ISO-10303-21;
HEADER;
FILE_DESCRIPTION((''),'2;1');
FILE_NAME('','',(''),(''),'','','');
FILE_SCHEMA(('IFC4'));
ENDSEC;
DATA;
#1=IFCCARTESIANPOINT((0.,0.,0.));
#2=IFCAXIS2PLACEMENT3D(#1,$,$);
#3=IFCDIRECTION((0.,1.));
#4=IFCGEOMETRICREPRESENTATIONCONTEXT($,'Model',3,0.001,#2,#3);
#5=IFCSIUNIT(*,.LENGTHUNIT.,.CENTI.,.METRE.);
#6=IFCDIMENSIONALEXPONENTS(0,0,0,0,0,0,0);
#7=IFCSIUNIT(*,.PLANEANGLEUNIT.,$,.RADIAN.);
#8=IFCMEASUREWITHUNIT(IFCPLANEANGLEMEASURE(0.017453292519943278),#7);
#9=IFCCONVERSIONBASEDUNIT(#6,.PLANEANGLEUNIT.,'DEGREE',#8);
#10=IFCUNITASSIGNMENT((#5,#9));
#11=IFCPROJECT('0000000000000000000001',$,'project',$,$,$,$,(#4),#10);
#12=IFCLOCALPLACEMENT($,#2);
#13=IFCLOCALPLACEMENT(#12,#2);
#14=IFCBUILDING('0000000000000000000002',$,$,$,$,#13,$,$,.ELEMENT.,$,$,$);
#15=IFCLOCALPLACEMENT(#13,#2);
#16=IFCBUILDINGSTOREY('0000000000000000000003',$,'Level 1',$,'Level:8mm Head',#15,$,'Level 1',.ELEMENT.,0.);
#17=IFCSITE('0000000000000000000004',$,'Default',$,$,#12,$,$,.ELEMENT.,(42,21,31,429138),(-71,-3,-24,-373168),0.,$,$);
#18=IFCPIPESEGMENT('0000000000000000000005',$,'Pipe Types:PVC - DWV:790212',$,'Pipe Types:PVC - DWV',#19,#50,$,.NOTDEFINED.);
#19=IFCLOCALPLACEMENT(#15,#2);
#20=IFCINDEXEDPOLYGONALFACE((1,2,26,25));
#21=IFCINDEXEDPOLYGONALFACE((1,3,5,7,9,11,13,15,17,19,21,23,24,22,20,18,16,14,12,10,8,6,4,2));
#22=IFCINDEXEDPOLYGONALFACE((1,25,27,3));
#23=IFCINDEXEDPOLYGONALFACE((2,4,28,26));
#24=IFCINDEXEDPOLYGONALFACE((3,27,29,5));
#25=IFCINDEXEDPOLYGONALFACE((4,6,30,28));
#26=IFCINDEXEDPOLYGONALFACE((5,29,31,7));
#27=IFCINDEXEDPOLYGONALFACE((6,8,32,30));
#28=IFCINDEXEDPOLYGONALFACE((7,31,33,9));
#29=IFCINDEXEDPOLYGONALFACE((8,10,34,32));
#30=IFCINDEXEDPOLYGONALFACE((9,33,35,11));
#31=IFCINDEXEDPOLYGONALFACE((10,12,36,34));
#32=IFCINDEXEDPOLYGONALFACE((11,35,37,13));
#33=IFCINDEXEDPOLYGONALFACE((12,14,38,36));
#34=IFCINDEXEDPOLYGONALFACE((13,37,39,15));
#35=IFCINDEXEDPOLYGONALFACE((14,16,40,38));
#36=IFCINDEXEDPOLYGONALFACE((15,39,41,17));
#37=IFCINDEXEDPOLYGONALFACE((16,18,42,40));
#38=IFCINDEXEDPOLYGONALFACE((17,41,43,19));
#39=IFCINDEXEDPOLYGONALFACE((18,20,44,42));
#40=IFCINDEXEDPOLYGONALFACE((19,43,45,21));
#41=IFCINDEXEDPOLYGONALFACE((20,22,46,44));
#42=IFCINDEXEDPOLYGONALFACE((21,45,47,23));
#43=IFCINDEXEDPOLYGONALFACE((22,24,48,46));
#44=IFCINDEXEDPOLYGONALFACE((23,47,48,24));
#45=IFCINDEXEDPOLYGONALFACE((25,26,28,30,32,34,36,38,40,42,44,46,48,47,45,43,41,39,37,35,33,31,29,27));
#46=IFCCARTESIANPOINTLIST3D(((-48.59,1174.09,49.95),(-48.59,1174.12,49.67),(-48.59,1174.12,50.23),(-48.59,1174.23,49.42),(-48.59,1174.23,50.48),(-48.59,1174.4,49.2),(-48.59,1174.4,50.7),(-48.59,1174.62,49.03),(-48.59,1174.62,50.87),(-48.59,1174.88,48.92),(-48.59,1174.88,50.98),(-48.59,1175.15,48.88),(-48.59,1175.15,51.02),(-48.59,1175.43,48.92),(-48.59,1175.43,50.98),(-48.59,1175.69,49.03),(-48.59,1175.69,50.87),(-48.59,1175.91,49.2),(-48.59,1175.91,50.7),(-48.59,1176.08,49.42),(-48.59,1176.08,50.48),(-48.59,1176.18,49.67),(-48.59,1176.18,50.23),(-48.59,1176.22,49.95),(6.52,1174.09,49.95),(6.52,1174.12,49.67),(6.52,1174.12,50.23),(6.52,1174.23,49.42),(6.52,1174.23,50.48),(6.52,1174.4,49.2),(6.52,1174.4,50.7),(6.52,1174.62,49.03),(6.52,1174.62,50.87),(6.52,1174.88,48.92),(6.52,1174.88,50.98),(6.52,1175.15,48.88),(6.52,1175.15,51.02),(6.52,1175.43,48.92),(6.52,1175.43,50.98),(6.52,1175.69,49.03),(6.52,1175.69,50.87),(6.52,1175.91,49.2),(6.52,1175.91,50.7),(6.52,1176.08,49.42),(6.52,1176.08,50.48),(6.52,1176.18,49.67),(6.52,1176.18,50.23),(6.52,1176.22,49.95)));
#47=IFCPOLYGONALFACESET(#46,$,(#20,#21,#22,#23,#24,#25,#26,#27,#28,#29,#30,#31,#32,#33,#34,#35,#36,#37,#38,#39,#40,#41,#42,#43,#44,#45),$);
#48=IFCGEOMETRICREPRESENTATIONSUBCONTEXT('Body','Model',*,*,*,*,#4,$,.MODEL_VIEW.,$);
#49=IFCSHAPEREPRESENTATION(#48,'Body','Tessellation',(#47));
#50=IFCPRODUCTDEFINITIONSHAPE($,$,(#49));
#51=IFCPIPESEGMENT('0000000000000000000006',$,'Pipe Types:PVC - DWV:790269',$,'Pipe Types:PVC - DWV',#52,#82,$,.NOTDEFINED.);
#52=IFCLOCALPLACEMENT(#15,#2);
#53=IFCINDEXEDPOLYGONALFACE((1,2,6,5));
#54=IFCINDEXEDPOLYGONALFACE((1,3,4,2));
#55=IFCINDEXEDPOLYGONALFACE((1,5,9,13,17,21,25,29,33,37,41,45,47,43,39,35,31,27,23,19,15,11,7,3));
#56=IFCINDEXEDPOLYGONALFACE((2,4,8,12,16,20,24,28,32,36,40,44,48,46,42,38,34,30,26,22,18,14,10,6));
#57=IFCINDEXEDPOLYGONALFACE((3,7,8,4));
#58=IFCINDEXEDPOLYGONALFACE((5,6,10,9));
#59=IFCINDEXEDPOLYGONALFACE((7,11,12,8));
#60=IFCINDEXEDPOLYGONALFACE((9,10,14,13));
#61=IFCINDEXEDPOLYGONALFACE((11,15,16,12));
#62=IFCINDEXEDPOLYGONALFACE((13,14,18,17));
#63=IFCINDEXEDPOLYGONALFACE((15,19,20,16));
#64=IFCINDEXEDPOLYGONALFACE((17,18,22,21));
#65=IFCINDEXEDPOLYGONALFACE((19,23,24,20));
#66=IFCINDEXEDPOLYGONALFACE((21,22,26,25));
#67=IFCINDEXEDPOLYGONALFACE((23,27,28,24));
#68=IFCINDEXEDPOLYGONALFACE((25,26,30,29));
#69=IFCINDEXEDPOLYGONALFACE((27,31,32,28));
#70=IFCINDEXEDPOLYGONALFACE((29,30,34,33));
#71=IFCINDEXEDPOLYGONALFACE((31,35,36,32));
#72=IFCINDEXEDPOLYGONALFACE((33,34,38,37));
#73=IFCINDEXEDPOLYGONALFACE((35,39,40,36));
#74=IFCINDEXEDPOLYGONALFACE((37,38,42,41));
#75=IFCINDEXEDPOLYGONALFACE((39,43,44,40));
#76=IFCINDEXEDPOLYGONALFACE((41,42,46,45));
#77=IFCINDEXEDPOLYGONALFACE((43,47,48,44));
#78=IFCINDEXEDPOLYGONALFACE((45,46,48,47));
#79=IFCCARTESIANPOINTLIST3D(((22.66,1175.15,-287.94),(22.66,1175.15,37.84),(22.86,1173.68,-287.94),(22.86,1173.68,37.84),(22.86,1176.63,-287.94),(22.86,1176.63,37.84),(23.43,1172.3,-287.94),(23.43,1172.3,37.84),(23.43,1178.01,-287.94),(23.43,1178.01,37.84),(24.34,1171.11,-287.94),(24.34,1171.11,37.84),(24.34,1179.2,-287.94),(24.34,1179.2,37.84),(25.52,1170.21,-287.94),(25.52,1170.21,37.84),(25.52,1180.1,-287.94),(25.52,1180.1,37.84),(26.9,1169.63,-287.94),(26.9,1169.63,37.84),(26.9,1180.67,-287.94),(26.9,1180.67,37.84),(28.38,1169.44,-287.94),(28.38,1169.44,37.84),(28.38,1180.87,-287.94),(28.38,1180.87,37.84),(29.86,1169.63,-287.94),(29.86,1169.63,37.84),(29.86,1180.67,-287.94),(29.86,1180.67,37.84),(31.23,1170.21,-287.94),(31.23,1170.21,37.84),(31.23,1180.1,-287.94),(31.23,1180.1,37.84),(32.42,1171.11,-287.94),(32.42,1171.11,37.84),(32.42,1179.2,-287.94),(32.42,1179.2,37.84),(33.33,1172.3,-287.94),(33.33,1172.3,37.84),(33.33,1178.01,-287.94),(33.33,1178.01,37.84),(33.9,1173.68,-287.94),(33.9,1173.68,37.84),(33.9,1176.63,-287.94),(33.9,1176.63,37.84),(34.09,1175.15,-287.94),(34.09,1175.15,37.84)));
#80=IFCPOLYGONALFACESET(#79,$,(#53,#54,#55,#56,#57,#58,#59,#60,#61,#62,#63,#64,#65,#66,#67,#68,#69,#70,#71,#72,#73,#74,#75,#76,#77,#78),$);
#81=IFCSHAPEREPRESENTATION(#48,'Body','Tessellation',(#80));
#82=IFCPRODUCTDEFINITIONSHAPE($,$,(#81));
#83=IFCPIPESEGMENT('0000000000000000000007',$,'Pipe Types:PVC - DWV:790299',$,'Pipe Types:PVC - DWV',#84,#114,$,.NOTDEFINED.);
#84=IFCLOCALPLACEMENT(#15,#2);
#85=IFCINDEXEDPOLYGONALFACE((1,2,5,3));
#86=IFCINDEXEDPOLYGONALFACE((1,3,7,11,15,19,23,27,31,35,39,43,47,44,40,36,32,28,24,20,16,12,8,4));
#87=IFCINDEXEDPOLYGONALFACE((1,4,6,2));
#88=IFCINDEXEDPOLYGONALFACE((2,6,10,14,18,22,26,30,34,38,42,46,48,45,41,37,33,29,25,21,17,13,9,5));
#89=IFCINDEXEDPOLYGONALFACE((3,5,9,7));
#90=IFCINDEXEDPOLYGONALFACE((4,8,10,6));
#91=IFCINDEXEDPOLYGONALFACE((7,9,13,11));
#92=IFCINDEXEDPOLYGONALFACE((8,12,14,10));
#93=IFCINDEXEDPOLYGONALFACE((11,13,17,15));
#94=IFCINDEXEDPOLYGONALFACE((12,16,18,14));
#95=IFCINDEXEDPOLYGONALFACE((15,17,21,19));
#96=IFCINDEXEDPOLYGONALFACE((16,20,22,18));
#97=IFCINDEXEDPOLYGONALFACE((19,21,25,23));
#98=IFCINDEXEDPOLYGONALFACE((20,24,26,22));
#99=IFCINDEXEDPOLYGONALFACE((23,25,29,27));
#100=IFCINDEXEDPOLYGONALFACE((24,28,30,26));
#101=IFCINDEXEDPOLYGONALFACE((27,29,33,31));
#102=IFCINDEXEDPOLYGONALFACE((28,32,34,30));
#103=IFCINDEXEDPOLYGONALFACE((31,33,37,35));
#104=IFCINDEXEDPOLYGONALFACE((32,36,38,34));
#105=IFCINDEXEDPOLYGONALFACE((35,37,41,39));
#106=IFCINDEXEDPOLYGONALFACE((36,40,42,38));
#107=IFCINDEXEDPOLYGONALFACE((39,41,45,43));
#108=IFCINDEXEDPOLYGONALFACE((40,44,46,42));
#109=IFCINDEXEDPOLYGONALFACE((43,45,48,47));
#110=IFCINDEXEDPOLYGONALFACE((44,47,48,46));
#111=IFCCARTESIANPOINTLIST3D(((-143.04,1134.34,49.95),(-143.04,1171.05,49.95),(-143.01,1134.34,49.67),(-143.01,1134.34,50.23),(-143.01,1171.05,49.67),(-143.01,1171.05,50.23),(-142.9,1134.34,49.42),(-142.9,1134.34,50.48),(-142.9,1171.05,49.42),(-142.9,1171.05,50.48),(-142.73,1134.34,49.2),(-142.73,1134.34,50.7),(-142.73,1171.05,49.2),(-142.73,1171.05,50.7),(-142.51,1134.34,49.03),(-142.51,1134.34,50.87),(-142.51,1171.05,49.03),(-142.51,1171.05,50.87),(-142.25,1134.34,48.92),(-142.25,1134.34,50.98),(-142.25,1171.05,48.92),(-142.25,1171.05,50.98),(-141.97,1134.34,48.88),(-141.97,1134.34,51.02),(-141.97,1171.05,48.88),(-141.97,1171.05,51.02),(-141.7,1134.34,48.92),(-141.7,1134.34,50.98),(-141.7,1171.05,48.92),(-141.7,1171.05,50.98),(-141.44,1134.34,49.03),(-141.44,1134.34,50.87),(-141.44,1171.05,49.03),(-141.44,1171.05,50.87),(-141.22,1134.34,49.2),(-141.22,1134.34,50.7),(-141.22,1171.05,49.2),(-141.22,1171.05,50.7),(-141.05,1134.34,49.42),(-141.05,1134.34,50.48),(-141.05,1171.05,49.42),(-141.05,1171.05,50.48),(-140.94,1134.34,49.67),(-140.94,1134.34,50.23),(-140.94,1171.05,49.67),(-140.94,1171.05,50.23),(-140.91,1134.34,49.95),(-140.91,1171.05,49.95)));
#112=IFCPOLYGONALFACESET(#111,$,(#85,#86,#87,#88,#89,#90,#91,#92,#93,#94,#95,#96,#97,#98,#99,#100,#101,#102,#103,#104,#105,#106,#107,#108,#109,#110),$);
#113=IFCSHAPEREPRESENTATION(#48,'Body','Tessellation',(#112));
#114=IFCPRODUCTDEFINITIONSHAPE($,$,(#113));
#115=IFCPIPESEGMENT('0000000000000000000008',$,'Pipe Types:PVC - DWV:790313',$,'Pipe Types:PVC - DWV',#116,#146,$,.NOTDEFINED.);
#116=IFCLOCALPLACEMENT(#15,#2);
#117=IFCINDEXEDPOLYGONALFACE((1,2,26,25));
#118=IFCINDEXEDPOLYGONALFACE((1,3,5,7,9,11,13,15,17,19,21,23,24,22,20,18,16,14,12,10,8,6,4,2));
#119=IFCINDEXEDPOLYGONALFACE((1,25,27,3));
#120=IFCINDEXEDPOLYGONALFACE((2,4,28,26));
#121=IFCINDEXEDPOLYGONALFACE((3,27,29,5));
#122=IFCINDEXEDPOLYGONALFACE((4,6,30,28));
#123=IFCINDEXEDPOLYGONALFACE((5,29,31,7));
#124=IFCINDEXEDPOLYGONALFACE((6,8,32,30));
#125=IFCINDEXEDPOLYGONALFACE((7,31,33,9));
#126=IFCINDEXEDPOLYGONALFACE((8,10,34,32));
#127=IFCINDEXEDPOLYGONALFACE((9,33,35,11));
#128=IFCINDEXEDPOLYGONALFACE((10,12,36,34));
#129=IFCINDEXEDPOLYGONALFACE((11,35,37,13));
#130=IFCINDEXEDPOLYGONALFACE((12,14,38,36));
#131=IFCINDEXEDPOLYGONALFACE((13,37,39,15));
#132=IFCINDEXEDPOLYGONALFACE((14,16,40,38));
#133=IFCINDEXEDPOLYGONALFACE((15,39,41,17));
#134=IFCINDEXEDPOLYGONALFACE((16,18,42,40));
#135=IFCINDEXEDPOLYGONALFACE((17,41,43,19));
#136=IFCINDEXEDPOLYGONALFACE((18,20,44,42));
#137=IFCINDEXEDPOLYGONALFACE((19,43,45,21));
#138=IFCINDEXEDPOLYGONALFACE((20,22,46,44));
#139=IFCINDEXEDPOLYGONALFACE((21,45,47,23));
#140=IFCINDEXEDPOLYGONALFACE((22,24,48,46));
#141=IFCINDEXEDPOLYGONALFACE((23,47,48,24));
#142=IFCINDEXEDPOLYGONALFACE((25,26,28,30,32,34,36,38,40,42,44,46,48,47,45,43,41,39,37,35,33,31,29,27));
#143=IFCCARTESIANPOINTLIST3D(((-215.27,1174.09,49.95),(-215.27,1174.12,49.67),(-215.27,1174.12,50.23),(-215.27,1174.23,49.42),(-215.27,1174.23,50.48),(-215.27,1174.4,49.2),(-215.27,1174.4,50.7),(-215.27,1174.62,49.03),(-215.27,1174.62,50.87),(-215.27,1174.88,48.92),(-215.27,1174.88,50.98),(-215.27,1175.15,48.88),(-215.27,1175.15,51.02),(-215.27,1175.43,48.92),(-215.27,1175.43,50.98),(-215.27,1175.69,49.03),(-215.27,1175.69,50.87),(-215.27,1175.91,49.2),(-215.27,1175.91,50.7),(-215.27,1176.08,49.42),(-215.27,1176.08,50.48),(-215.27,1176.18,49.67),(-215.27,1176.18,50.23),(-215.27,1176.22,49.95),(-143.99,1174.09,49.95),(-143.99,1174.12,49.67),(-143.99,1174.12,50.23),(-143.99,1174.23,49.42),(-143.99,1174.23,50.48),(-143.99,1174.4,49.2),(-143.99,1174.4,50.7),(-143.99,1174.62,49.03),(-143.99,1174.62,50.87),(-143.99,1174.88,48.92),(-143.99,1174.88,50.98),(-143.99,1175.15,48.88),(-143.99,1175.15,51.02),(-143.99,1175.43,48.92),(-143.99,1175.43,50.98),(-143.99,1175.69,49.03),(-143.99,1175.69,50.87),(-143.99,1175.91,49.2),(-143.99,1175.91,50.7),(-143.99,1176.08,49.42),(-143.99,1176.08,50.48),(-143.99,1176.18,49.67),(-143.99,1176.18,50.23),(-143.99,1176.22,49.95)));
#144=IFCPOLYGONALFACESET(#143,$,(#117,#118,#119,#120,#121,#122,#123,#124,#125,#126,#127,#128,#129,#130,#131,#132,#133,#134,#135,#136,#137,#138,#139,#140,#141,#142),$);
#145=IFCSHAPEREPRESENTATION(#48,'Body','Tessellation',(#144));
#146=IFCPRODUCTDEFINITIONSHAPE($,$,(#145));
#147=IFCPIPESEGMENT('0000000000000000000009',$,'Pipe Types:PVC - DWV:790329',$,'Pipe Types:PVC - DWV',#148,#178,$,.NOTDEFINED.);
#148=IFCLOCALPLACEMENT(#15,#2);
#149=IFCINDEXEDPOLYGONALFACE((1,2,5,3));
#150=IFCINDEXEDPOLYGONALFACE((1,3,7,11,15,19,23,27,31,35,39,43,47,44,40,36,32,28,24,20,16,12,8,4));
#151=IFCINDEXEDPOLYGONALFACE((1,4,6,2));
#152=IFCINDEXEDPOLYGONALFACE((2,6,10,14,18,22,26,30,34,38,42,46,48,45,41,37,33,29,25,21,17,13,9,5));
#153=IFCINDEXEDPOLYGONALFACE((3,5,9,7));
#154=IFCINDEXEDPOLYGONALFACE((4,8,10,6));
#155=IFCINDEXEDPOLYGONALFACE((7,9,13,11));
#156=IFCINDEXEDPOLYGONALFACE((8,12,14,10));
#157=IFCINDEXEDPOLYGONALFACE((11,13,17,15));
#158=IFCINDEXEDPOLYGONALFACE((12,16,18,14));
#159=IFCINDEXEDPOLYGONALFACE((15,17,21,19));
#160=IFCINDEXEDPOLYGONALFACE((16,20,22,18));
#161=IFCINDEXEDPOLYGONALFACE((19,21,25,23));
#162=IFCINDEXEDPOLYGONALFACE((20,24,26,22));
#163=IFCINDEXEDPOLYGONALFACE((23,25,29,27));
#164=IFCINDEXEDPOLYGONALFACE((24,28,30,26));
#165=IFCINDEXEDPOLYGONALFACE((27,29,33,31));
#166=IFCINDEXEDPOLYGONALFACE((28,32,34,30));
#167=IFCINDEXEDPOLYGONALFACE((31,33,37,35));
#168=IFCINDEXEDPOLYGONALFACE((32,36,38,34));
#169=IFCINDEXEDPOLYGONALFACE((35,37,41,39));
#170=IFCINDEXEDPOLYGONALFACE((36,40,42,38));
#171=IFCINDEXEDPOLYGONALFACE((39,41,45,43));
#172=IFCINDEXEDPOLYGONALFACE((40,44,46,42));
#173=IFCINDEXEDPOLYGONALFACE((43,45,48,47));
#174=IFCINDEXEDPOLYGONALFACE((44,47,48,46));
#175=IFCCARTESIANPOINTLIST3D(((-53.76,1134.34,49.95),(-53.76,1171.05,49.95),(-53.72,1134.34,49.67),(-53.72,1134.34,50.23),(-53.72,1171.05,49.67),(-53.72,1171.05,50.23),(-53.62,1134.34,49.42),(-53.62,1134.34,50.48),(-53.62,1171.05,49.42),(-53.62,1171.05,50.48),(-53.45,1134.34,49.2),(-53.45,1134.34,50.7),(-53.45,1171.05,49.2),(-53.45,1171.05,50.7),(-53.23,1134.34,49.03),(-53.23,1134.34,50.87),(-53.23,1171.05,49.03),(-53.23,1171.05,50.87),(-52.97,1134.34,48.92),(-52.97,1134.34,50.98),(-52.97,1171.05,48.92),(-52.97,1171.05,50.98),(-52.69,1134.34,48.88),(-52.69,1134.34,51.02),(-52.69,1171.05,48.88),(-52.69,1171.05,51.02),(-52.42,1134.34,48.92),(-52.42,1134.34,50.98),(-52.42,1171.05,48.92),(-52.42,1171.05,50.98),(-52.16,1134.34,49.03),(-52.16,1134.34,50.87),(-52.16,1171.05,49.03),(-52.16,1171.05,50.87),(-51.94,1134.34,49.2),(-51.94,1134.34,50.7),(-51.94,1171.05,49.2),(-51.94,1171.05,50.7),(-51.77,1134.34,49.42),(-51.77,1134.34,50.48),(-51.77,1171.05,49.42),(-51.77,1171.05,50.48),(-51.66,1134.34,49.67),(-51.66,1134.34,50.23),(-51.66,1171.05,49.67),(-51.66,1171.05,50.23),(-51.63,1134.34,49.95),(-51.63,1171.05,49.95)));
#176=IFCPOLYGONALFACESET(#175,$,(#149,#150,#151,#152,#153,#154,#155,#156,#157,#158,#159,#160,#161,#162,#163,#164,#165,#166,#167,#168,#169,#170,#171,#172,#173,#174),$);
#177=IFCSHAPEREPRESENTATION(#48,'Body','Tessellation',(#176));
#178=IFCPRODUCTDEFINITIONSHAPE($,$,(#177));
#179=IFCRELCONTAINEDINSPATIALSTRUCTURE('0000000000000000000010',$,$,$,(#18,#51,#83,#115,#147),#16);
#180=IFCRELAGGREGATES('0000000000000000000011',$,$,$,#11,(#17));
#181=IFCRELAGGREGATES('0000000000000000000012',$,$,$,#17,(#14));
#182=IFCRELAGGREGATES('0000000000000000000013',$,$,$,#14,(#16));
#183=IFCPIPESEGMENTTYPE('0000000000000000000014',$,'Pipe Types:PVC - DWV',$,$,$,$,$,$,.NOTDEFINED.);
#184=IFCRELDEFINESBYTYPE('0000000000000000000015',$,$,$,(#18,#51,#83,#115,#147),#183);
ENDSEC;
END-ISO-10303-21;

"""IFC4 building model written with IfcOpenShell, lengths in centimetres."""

from ifc_helpers import new_model, entity, si_unit, converted_unit, direction, frame, origin, place, context, subcontext, project, spatial, arc, indexed_curve, outline, extrude, type_object, element, save


model = new_model("IFC4")

# Units and contexts
model_context = context("Model", 3, precision=0.001, world=origin(), true_north=direction((0.0, 1.0)))
body_context = subcontext(model_context, "Body", "Model", "MODEL_VIEW")
ifc_project = project(units=[si_unit("LENGTHUNIT", "METRE", prefix="CENTI"), converted_unit("PLANEANGLEUNIT", "DEGREE", entity("IfcPlaneAngleMeasure", 0.017453292519943278), si_unit("PLANEANGLEUNIT", "RADIAN"), dimensions=[0, 0, 0, 0, 0, 0, 0])], contexts=[model_context])

# Site, building, storey
site_placement = place(None, origin())
site = spatial("IfcSite", under=ifc_project, at=site_placement, Name="Default", CompositionType="ELEMENT", RefLatitude=(42, 21, 31, 429138), RefLongitude=(-71, -3, -24, -373168), RefElevation=0.0)
building_placement = place(site_placement, origin())
building = spatial("IfcBuilding", under=site, at=building_placement, CompositionType="ELEMENT")
storey_placement = place(building_placement, origin())
storey = spatial("IfcBuildingStorey", under=building, at=storey_placement, Name="Level 1", ObjectType="Level:8mm Head", LongName="Level 1", CompositionType="ELEMENT", Elevation=0.0)

# Pipe segments
pipe_segment_type = type_object("IfcPipeSegmentType", Name="Pipe Types:PVC - DWV", PredefinedType="NOTDEFINED")
pipe_segment_1_placement = place(storey_placement, origin())
element("IfcPipeSegment", 1, at=pipe_segment_1_placement, inside=storey, type_object=pipe_segment_type, Name="Pipe Types:PVC - DWV:790212", ObjectType="Pipe Types:PVC - DWV", PredefinedType="NOTDEFINED", context=body_context, shape_type="SweptSolid", body=[
    extrude(outline(indexed_curve([(1.07, 0.0), (0.75, 0.75), (0.0, 1.07), (-0.75, 0.75), (-1.07, 0.0), (-0.75, -0.75), (0.0, -1.07), (0.75, -0.75)], segments=[arc(1, 2, 3), arc(3, 4, 5), arc(5, 6, 7), arc(7, 8, 1)], self_intersect=False)), frame((-48.59, 1175.15, 49.95), z_axis=(1.0, 0.0, 0.0), x_axis=(0.0, -1.0, 0.0)), (0.0, 0.0, 1.0), 55.11),
])
pipe_segment_2_placement = place(storey_placement, origin())
element("IfcPipeSegment", 2, at=pipe_segment_2_placement, inside=storey, type_object=pipe_segment_type, Name="Pipe Types:PVC - DWV:790269", ObjectType="Pipe Types:PVC - DWV", PredefinedType="NOTDEFINED", context=body_context, shape_type="SweptSolid", body=[
    extrude(outline(indexed_curve([(5.72, 0.0), (4.04, 4.04), (0.0, 5.71), (-4.04, 4.04), (-5.71, 0.0), (-4.04, -4.04), (0.0, -5.71), (4.04, -4.04)], segments=[arc(1, 2, 3), arc(3, 4, 5), arc(5, 6, 7), arc(7, 8, 1)], self_intersect=False)), frame((28.38, 1175.15, -287.94), z_axis=(0.0, 0.0, 1.0), x_axis=(-1.0, 0.0, 0.0)), (0.0, 0.0, 1.0), 325.78),
])
pipe_segment_3_placement = place(storey_placement, origin())
element("IfcPipeSegment", 3, at=pipe_segment_3_placement, inside=storey, type_object=pipe_segment_type, Name="Pipe Types:PVC - DWV:790299", ObjectType="Pipe Types:PVC - DWV", PredefinedType="NOTDEFINED", context=body_context, shape_type="SweptSolid", body=[
    extrude(outline(indexed_curve([(1.07, 0.0), (0.75, 0.75), (0.0, 1.07), (-0.75, 0.75), (-1.07, 0.0), (-0.75, -0.75), (0.0, -1.07), (0.75, -0.75)], segments=[arc(1, 2, 3), arc(3, 4, 5), arc(5, 6, 7), arc(7, 8, 1)], self_intersect=False)), frame((-141.97, 1134.34, 49.95), z_axis=(0.0, 1.0, 0.0), x_axis=(-1.0, 0.0, 0.0)), (0.0, 0.0, 1.0), 36.71),
])
pipe_segment_4_placement = place(storey_placement, origin())
element("IfcPipeSegment", 4, at=pipe_segment_4_placement, inside=storey, type_object=pipe_segment_type, Name="Pipe Types:PVC - DWV:790313", ObjectType="Pipe Types:PVC - DWV", PredefinedType="NOTDEFINED", context=body_context, shape_type="SweptSolid", body=[
    extrude(outline(indexed_curve([(1.07, 0.0), (0.75, 0.75), (0.0, 1.07), (-0.75, 0.75), (-1.07, 0.0), (-0.75, -0.75), (0.0, -1.07), (0.75, -0.75)], segments=[arc(1, 2, 3), arc(3, 4, 5), arc(5, 6, 7), arc(7, 8, 1)], self_intersect=False)), frame((-215.27, 1175.15, 49.95), z_axis=(1.0, 0.0, 0.0), x_axis=(0.0, -1.0, 0.0)), (0.0, 0.0, 1.0), 71.29),
])
pipe_segment_5_placement = place(storey_placement, origin())
element("IfcPipeSegment", 5, at=pipe_segment_5_placement, inside=storey, type_object=pipe_segment_type, Name="Pipe Types:PVC - DWV:790329", ObjectType="Pipe Types:PVC - DWV", PredefinedType="NOTDEFINED", context=body_context, shape_type="SweptSolid", body=[
    extrude(outline(indexed_curve([(1.07, 0.0), (0.75, 0.75), (0.0, 1.07), (-0.75, 0.75), (-1.07, 0.0), (-0.75, -0.75), (0.0, -1.07), (0.75, -0.75)], segments=[arc(1, 2, 3), arc(3, 4, 5), arc(5, 6, 7), arc(7, 8, 1)], self_intersect=False)), frame((-52.69, 1134.34, 49.95), z_axis=(0.0, 1.0, 0.0), x_axis=(-1.0, 0.0, 0.0)), (0.0, 0.0, 1.0), 36.71),
])

save(model, "model.ifc")
